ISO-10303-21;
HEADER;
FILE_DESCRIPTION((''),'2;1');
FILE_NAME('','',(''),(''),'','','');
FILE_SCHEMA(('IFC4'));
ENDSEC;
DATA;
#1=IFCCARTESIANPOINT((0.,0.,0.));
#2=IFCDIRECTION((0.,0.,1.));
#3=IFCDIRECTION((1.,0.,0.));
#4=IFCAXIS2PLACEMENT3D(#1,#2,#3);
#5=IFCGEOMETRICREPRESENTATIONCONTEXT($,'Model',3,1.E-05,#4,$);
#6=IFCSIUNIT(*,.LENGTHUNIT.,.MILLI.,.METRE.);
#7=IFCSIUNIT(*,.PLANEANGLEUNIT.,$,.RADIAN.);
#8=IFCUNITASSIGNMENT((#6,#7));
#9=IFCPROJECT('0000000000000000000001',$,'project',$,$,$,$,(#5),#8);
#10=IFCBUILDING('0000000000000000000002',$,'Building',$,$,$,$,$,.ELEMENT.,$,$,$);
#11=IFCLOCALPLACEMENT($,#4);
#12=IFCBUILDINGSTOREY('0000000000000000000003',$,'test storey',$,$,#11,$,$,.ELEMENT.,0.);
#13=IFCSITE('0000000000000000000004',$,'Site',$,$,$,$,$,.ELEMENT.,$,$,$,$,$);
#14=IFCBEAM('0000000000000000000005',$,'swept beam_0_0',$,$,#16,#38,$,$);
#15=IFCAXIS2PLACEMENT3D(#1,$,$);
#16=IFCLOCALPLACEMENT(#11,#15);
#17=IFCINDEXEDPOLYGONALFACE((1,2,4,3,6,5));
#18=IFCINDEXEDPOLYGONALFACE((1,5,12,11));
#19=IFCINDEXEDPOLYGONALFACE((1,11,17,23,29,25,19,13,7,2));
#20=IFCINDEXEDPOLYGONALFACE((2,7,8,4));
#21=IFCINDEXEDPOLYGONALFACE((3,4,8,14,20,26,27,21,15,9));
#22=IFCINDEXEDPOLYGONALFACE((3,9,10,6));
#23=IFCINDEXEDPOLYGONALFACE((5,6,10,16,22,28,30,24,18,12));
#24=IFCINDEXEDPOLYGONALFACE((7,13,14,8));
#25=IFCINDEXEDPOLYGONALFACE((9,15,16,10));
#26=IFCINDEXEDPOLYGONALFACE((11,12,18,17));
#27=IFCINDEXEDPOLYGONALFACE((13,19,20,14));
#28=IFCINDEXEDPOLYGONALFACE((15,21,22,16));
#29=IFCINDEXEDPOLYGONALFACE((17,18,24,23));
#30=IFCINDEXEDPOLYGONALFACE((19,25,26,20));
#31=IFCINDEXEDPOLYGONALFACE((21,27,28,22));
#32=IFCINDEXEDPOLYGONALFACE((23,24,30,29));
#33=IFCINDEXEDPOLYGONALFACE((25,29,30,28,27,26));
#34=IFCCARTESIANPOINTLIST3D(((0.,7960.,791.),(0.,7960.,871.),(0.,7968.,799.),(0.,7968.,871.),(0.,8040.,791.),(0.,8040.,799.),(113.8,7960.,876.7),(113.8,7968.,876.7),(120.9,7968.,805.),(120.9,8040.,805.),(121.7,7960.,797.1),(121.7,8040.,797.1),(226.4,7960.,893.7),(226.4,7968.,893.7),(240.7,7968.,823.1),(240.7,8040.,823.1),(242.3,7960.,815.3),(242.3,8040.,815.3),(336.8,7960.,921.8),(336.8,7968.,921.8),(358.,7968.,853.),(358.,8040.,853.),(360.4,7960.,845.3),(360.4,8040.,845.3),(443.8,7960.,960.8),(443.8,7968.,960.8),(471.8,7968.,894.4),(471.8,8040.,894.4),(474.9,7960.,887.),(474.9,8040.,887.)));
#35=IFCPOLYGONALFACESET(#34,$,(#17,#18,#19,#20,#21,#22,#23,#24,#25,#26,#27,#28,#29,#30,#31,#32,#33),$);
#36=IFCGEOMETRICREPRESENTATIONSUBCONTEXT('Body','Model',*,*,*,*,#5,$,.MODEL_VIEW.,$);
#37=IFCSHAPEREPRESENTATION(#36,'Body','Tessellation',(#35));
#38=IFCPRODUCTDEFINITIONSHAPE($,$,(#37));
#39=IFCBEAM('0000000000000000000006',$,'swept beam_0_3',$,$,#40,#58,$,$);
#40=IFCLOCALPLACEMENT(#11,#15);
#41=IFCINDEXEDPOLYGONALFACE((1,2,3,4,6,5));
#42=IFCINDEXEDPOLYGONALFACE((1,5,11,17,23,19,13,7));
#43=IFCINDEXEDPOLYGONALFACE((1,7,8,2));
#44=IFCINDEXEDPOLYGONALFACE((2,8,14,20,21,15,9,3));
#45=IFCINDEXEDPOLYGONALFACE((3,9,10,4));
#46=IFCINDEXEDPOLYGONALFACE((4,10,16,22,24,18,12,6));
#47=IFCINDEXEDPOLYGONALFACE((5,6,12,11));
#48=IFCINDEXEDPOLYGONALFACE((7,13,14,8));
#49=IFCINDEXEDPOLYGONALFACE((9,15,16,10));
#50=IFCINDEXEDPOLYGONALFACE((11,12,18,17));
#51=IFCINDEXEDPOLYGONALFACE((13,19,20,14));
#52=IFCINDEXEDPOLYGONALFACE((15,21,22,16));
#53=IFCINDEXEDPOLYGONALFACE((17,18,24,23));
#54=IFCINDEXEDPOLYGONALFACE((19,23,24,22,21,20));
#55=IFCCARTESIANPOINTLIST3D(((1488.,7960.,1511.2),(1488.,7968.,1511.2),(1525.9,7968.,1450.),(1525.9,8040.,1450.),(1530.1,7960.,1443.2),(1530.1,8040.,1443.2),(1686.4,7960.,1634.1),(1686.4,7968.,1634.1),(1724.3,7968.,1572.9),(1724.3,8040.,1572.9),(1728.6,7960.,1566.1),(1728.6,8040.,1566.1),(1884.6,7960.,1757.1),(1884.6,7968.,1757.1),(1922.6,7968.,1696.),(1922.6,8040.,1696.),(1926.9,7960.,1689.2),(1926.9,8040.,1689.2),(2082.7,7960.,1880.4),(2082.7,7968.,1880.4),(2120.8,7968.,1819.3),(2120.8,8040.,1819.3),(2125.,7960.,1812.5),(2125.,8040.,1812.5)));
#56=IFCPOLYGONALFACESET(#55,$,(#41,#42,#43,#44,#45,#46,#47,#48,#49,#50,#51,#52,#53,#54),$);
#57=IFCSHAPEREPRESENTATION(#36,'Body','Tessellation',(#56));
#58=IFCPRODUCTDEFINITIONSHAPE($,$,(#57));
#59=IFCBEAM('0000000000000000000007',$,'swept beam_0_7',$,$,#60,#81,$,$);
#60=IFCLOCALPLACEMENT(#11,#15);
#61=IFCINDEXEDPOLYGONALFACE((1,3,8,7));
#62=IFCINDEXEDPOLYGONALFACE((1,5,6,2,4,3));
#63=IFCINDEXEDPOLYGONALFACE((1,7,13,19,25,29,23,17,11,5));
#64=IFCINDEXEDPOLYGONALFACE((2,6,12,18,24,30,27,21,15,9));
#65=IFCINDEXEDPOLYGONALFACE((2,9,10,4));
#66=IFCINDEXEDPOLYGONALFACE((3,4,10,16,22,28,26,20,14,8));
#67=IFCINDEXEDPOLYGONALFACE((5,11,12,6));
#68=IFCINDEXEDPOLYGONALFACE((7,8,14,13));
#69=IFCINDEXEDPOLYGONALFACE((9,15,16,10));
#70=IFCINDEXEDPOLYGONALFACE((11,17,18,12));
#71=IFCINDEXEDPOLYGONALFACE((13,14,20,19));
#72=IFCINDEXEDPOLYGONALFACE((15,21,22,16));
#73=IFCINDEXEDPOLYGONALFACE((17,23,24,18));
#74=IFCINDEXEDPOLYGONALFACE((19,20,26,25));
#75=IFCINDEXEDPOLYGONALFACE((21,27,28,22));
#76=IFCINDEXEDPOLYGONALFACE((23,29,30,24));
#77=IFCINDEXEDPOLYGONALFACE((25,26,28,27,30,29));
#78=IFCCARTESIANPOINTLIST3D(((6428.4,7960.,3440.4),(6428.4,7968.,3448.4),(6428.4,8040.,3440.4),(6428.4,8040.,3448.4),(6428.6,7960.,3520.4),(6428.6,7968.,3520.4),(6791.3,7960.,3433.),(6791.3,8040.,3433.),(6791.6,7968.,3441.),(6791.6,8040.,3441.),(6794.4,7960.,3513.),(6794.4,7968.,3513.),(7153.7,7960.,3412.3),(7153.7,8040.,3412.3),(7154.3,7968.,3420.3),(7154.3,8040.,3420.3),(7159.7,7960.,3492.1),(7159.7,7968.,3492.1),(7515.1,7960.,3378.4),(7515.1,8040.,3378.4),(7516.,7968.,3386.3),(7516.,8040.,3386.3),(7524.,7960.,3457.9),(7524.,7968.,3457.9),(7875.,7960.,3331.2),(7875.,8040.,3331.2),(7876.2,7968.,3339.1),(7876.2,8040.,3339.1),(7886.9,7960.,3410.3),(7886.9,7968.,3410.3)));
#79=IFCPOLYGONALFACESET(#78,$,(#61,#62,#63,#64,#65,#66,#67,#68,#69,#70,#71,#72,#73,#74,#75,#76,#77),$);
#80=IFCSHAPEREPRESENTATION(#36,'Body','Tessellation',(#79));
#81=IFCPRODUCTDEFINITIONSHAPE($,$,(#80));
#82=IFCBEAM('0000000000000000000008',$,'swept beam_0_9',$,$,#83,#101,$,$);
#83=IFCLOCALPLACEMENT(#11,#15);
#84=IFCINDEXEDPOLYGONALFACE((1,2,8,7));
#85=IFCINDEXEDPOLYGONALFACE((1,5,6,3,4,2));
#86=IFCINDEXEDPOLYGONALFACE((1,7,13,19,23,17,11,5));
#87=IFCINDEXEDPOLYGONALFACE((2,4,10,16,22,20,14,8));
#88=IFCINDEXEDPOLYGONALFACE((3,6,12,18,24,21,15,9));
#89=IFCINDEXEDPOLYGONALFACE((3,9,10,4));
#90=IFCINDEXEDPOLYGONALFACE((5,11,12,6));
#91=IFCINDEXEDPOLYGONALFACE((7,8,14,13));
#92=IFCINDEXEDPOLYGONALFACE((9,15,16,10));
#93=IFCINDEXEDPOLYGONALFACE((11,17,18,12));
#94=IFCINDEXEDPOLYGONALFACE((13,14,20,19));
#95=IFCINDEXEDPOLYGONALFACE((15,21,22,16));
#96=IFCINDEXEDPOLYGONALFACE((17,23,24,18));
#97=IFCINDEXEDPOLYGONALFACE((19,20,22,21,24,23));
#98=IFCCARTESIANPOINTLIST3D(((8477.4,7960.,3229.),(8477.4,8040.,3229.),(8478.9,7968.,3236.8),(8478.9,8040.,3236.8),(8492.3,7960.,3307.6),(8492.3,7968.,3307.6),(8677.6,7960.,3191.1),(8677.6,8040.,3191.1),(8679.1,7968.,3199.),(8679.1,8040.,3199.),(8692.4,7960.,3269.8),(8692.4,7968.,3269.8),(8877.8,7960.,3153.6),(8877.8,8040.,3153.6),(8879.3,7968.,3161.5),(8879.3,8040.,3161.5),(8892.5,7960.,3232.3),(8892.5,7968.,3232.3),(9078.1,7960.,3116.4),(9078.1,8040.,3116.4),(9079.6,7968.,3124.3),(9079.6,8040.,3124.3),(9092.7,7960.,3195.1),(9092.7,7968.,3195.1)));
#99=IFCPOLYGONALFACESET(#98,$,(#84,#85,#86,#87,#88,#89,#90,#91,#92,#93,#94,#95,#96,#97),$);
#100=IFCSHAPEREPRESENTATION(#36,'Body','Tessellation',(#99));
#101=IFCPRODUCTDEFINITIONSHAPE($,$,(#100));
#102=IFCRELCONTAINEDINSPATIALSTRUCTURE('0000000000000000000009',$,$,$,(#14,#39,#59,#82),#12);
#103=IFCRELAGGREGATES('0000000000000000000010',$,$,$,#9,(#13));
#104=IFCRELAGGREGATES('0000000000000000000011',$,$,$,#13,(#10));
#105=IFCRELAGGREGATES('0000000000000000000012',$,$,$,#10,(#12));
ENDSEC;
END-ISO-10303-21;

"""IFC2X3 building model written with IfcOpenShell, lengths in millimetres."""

from ifc_helpers import new_model, entity, si_unit, origin_with_axes, place, context, subcontext, project, spatial, element, save


model = new_model("IFC2X3")

# Units and contexts
model_context = context("Model", 3, precision=1e-05, world=origin_with_axes())
body_context = subcontext(model_context, "Body", "Model", "MODEL_VIEW")
ifc_project = project(units=[si_unit("LENGTHUNIT", "METRE", prefix="MILLI"), si_unit("PLANEANGLEUNIT", "RADIAN")], contexts=[model_context])

# Site, building, storey
site = spatial("IfcSite", under=ifc_project, Name="Site", CompositionType="ELEMENT")
building = spatial("IfcBuilding", under=site, Name="Building", CompositionType="ELEMENT")
storey_placement = place(None, origin_with_axes())
storey = spatial("IfcBuildingStorey", under=building, at=storey_placement, Name="test storey", CompositionType="ELEMENT", Elevation=0.0)

# Beams
beam_1_placement = place(storey_placement, origin_with_axes())
element("IfcBeam", 1, at=beam_1_placement, inside=storey, Name="swept beam_0_0", context=body_context, shape_type="SweptSolid", body=[
    entity("IfcRevolvedAreaSolid", entity("IfcArbitraryClosedProfileDef", "AREA", None, entity("IfcPolyline", [entity("IfcCartesianPoint", [-80.0, 40.0]), entity("IfcCartesianPoint", [-80.0, 32.0]), entity("IfcCartesianPoint", [-8.0, 32.0]), entity("IfcCartesianPoint", [-8.0, -40.0]), entity("IfcCartesianPoint", [0.0, -40.0]), entity("IfcCartesianPoint", [0.0, 40.0]), entity("IfcCartesianPoint", [-80.0, 40.0])])), entity("IfcAxis2Placement3D", entity("IfcCartesianPoint", [0.0, 8000.0, 791.0]), entity("IfcDirection", [-1.0, 0.0, 0.0]), entity("IfcDirection", [0.0, 0.0, -1.0])), entity("IfcAxis1Placement", entity("IfcCartesianPoint", [-1222.2, 0.0, 0.0]), entity("IfcDirection", [0.0, 1.0, 0.0])), 0.399077),
])
beam_2_placement = place(storey_placement, origin_with_axes())
element("IfcBeam", 2, at=beam_2_placement, inside=storey, Name="swept beam_0_3", context=body_context, shape_type="SweptSolid", body=[
    entity("IfcRevolvedAreaSolid", entity("IfcArbitraryClosedProfileDef", "AREA", None, entity("IfcPolyline", [entity("IfcCartesianPoint", [-80.0, 40.0]), entity("IfcCartesianPoint", [-80.0, 32.0]), entity("IfcCartesianPoint", [-8.0, 32.0]), entity("IfcCartesianPoint", [-8.0, -40.0]), entity("IfcCartesianPoint", [0.0, -40.0]), entity("IfcCartesianPoint", [0.0, 40.0]), entity("IfcCartesianPoint", [-80.0, 40.0])])), entity("IfcAxis2Placement3D", entity("IfcCartesianPoint", [1530.1, 8000.0, 1443.2]), entity("IfcDirection", [-0.8505, 0.0, -0.526]), entity("IfcDirection", [0.526, 0.0, -0.8505])), entity("IfcAxis1Placement", entity("IfcCartesianPoint", [-207824.9, 0.0, 0.0]), entity("IfcDirection", [0.0, 1.0, 0.0])), 0.003369),
])
beam_3_placement = place(storey_placement, origin_with_axes())
element("IfcBeam", 3, at=beam_3_placement, inside=storey, Name="swept beam_0_7", context=body_context, shape_type="SweptSolid", body=[
    entity("IfcRevolvedAreaSolid", entity("IfcArbitraryClosedProfileDef", "AREA", None, entity("IfcPolyline", [entity("IfcCartesianPoint", [80.0, -40.0]), entity("IfcCartesianPoint", [80.0, -32.0]), entity("IfcCartesianPoint", [8.0, -32.0]), entity("IfcCartesianPoint", [8.0, 40.0]), entity("IfcCartesianPoint", [0.0, 40.0]), entity("IfcCartesianPoint", [0.0, -40.0]), entity("IfcCartesianPoint", [80.0, -40.0])])), entity("IfcAxis2Placement3D", entity("IfcCartesianPoint", [6428.4, 8000.0, 3440.4]), entity("IfcDirection", [-1.0, 0.0, 0.002]), entity("IfcDirection", [0.002, 0.0, 1.0])), entity("IfcAxis1Placement", entity("IfcCartesianPoint", [-9894.2, 0.0, 0.0]), entity("IfcDirection", [0.0, 1.0, 0.0])), 0.146754),
])
beam_4_placement = place(storey_placement, origin_with_axes())
element("IfcBeam", 4, at=beam_4_placement, inside=storey, Name="swept beam_0_9", context=body_context, shape_type="SweptSolid", body=[
    entity("IfcRevolvedAreaSolid", entity("IfcArbitraryClosedProfileDef", "AREA", None, entity("IfcPolyline", [entity("IfcCartesianPoint", [-80.0, 40.0]), entity("IfcCartesianPoint", [-80.0, 32.0]), entity("IfcCartesianPoint", [-8.0, 32.0]), entity("IfcCartesianPoint", [-8.0, -40.0]), entity("IfcCartesianPoint", [0.0, -40.0]), entity("IfcCartesianPoint", [0.0, 40.0]), entity("IfcCartesianPoint", [-80.0, 40.0])])), entity("IfcAxis2Placement3D", entity("IfcCartesianPoint", [8477.4, 8000.0, 3229.0]), entity("IfcDirection", [-0.9825, 0.0, 0.1865]), entity("IfcDirection", [-0.1865, 0.0, -0.9825])), entity("IfcAxis1Placement", entity("IfcCartesianPoint", [-127077.6, 0.0, 0.0]), entity("IfcDirection", [0.0, 1.0, 0.0])), 0.004809),
])

save(model, "model.ifc")
